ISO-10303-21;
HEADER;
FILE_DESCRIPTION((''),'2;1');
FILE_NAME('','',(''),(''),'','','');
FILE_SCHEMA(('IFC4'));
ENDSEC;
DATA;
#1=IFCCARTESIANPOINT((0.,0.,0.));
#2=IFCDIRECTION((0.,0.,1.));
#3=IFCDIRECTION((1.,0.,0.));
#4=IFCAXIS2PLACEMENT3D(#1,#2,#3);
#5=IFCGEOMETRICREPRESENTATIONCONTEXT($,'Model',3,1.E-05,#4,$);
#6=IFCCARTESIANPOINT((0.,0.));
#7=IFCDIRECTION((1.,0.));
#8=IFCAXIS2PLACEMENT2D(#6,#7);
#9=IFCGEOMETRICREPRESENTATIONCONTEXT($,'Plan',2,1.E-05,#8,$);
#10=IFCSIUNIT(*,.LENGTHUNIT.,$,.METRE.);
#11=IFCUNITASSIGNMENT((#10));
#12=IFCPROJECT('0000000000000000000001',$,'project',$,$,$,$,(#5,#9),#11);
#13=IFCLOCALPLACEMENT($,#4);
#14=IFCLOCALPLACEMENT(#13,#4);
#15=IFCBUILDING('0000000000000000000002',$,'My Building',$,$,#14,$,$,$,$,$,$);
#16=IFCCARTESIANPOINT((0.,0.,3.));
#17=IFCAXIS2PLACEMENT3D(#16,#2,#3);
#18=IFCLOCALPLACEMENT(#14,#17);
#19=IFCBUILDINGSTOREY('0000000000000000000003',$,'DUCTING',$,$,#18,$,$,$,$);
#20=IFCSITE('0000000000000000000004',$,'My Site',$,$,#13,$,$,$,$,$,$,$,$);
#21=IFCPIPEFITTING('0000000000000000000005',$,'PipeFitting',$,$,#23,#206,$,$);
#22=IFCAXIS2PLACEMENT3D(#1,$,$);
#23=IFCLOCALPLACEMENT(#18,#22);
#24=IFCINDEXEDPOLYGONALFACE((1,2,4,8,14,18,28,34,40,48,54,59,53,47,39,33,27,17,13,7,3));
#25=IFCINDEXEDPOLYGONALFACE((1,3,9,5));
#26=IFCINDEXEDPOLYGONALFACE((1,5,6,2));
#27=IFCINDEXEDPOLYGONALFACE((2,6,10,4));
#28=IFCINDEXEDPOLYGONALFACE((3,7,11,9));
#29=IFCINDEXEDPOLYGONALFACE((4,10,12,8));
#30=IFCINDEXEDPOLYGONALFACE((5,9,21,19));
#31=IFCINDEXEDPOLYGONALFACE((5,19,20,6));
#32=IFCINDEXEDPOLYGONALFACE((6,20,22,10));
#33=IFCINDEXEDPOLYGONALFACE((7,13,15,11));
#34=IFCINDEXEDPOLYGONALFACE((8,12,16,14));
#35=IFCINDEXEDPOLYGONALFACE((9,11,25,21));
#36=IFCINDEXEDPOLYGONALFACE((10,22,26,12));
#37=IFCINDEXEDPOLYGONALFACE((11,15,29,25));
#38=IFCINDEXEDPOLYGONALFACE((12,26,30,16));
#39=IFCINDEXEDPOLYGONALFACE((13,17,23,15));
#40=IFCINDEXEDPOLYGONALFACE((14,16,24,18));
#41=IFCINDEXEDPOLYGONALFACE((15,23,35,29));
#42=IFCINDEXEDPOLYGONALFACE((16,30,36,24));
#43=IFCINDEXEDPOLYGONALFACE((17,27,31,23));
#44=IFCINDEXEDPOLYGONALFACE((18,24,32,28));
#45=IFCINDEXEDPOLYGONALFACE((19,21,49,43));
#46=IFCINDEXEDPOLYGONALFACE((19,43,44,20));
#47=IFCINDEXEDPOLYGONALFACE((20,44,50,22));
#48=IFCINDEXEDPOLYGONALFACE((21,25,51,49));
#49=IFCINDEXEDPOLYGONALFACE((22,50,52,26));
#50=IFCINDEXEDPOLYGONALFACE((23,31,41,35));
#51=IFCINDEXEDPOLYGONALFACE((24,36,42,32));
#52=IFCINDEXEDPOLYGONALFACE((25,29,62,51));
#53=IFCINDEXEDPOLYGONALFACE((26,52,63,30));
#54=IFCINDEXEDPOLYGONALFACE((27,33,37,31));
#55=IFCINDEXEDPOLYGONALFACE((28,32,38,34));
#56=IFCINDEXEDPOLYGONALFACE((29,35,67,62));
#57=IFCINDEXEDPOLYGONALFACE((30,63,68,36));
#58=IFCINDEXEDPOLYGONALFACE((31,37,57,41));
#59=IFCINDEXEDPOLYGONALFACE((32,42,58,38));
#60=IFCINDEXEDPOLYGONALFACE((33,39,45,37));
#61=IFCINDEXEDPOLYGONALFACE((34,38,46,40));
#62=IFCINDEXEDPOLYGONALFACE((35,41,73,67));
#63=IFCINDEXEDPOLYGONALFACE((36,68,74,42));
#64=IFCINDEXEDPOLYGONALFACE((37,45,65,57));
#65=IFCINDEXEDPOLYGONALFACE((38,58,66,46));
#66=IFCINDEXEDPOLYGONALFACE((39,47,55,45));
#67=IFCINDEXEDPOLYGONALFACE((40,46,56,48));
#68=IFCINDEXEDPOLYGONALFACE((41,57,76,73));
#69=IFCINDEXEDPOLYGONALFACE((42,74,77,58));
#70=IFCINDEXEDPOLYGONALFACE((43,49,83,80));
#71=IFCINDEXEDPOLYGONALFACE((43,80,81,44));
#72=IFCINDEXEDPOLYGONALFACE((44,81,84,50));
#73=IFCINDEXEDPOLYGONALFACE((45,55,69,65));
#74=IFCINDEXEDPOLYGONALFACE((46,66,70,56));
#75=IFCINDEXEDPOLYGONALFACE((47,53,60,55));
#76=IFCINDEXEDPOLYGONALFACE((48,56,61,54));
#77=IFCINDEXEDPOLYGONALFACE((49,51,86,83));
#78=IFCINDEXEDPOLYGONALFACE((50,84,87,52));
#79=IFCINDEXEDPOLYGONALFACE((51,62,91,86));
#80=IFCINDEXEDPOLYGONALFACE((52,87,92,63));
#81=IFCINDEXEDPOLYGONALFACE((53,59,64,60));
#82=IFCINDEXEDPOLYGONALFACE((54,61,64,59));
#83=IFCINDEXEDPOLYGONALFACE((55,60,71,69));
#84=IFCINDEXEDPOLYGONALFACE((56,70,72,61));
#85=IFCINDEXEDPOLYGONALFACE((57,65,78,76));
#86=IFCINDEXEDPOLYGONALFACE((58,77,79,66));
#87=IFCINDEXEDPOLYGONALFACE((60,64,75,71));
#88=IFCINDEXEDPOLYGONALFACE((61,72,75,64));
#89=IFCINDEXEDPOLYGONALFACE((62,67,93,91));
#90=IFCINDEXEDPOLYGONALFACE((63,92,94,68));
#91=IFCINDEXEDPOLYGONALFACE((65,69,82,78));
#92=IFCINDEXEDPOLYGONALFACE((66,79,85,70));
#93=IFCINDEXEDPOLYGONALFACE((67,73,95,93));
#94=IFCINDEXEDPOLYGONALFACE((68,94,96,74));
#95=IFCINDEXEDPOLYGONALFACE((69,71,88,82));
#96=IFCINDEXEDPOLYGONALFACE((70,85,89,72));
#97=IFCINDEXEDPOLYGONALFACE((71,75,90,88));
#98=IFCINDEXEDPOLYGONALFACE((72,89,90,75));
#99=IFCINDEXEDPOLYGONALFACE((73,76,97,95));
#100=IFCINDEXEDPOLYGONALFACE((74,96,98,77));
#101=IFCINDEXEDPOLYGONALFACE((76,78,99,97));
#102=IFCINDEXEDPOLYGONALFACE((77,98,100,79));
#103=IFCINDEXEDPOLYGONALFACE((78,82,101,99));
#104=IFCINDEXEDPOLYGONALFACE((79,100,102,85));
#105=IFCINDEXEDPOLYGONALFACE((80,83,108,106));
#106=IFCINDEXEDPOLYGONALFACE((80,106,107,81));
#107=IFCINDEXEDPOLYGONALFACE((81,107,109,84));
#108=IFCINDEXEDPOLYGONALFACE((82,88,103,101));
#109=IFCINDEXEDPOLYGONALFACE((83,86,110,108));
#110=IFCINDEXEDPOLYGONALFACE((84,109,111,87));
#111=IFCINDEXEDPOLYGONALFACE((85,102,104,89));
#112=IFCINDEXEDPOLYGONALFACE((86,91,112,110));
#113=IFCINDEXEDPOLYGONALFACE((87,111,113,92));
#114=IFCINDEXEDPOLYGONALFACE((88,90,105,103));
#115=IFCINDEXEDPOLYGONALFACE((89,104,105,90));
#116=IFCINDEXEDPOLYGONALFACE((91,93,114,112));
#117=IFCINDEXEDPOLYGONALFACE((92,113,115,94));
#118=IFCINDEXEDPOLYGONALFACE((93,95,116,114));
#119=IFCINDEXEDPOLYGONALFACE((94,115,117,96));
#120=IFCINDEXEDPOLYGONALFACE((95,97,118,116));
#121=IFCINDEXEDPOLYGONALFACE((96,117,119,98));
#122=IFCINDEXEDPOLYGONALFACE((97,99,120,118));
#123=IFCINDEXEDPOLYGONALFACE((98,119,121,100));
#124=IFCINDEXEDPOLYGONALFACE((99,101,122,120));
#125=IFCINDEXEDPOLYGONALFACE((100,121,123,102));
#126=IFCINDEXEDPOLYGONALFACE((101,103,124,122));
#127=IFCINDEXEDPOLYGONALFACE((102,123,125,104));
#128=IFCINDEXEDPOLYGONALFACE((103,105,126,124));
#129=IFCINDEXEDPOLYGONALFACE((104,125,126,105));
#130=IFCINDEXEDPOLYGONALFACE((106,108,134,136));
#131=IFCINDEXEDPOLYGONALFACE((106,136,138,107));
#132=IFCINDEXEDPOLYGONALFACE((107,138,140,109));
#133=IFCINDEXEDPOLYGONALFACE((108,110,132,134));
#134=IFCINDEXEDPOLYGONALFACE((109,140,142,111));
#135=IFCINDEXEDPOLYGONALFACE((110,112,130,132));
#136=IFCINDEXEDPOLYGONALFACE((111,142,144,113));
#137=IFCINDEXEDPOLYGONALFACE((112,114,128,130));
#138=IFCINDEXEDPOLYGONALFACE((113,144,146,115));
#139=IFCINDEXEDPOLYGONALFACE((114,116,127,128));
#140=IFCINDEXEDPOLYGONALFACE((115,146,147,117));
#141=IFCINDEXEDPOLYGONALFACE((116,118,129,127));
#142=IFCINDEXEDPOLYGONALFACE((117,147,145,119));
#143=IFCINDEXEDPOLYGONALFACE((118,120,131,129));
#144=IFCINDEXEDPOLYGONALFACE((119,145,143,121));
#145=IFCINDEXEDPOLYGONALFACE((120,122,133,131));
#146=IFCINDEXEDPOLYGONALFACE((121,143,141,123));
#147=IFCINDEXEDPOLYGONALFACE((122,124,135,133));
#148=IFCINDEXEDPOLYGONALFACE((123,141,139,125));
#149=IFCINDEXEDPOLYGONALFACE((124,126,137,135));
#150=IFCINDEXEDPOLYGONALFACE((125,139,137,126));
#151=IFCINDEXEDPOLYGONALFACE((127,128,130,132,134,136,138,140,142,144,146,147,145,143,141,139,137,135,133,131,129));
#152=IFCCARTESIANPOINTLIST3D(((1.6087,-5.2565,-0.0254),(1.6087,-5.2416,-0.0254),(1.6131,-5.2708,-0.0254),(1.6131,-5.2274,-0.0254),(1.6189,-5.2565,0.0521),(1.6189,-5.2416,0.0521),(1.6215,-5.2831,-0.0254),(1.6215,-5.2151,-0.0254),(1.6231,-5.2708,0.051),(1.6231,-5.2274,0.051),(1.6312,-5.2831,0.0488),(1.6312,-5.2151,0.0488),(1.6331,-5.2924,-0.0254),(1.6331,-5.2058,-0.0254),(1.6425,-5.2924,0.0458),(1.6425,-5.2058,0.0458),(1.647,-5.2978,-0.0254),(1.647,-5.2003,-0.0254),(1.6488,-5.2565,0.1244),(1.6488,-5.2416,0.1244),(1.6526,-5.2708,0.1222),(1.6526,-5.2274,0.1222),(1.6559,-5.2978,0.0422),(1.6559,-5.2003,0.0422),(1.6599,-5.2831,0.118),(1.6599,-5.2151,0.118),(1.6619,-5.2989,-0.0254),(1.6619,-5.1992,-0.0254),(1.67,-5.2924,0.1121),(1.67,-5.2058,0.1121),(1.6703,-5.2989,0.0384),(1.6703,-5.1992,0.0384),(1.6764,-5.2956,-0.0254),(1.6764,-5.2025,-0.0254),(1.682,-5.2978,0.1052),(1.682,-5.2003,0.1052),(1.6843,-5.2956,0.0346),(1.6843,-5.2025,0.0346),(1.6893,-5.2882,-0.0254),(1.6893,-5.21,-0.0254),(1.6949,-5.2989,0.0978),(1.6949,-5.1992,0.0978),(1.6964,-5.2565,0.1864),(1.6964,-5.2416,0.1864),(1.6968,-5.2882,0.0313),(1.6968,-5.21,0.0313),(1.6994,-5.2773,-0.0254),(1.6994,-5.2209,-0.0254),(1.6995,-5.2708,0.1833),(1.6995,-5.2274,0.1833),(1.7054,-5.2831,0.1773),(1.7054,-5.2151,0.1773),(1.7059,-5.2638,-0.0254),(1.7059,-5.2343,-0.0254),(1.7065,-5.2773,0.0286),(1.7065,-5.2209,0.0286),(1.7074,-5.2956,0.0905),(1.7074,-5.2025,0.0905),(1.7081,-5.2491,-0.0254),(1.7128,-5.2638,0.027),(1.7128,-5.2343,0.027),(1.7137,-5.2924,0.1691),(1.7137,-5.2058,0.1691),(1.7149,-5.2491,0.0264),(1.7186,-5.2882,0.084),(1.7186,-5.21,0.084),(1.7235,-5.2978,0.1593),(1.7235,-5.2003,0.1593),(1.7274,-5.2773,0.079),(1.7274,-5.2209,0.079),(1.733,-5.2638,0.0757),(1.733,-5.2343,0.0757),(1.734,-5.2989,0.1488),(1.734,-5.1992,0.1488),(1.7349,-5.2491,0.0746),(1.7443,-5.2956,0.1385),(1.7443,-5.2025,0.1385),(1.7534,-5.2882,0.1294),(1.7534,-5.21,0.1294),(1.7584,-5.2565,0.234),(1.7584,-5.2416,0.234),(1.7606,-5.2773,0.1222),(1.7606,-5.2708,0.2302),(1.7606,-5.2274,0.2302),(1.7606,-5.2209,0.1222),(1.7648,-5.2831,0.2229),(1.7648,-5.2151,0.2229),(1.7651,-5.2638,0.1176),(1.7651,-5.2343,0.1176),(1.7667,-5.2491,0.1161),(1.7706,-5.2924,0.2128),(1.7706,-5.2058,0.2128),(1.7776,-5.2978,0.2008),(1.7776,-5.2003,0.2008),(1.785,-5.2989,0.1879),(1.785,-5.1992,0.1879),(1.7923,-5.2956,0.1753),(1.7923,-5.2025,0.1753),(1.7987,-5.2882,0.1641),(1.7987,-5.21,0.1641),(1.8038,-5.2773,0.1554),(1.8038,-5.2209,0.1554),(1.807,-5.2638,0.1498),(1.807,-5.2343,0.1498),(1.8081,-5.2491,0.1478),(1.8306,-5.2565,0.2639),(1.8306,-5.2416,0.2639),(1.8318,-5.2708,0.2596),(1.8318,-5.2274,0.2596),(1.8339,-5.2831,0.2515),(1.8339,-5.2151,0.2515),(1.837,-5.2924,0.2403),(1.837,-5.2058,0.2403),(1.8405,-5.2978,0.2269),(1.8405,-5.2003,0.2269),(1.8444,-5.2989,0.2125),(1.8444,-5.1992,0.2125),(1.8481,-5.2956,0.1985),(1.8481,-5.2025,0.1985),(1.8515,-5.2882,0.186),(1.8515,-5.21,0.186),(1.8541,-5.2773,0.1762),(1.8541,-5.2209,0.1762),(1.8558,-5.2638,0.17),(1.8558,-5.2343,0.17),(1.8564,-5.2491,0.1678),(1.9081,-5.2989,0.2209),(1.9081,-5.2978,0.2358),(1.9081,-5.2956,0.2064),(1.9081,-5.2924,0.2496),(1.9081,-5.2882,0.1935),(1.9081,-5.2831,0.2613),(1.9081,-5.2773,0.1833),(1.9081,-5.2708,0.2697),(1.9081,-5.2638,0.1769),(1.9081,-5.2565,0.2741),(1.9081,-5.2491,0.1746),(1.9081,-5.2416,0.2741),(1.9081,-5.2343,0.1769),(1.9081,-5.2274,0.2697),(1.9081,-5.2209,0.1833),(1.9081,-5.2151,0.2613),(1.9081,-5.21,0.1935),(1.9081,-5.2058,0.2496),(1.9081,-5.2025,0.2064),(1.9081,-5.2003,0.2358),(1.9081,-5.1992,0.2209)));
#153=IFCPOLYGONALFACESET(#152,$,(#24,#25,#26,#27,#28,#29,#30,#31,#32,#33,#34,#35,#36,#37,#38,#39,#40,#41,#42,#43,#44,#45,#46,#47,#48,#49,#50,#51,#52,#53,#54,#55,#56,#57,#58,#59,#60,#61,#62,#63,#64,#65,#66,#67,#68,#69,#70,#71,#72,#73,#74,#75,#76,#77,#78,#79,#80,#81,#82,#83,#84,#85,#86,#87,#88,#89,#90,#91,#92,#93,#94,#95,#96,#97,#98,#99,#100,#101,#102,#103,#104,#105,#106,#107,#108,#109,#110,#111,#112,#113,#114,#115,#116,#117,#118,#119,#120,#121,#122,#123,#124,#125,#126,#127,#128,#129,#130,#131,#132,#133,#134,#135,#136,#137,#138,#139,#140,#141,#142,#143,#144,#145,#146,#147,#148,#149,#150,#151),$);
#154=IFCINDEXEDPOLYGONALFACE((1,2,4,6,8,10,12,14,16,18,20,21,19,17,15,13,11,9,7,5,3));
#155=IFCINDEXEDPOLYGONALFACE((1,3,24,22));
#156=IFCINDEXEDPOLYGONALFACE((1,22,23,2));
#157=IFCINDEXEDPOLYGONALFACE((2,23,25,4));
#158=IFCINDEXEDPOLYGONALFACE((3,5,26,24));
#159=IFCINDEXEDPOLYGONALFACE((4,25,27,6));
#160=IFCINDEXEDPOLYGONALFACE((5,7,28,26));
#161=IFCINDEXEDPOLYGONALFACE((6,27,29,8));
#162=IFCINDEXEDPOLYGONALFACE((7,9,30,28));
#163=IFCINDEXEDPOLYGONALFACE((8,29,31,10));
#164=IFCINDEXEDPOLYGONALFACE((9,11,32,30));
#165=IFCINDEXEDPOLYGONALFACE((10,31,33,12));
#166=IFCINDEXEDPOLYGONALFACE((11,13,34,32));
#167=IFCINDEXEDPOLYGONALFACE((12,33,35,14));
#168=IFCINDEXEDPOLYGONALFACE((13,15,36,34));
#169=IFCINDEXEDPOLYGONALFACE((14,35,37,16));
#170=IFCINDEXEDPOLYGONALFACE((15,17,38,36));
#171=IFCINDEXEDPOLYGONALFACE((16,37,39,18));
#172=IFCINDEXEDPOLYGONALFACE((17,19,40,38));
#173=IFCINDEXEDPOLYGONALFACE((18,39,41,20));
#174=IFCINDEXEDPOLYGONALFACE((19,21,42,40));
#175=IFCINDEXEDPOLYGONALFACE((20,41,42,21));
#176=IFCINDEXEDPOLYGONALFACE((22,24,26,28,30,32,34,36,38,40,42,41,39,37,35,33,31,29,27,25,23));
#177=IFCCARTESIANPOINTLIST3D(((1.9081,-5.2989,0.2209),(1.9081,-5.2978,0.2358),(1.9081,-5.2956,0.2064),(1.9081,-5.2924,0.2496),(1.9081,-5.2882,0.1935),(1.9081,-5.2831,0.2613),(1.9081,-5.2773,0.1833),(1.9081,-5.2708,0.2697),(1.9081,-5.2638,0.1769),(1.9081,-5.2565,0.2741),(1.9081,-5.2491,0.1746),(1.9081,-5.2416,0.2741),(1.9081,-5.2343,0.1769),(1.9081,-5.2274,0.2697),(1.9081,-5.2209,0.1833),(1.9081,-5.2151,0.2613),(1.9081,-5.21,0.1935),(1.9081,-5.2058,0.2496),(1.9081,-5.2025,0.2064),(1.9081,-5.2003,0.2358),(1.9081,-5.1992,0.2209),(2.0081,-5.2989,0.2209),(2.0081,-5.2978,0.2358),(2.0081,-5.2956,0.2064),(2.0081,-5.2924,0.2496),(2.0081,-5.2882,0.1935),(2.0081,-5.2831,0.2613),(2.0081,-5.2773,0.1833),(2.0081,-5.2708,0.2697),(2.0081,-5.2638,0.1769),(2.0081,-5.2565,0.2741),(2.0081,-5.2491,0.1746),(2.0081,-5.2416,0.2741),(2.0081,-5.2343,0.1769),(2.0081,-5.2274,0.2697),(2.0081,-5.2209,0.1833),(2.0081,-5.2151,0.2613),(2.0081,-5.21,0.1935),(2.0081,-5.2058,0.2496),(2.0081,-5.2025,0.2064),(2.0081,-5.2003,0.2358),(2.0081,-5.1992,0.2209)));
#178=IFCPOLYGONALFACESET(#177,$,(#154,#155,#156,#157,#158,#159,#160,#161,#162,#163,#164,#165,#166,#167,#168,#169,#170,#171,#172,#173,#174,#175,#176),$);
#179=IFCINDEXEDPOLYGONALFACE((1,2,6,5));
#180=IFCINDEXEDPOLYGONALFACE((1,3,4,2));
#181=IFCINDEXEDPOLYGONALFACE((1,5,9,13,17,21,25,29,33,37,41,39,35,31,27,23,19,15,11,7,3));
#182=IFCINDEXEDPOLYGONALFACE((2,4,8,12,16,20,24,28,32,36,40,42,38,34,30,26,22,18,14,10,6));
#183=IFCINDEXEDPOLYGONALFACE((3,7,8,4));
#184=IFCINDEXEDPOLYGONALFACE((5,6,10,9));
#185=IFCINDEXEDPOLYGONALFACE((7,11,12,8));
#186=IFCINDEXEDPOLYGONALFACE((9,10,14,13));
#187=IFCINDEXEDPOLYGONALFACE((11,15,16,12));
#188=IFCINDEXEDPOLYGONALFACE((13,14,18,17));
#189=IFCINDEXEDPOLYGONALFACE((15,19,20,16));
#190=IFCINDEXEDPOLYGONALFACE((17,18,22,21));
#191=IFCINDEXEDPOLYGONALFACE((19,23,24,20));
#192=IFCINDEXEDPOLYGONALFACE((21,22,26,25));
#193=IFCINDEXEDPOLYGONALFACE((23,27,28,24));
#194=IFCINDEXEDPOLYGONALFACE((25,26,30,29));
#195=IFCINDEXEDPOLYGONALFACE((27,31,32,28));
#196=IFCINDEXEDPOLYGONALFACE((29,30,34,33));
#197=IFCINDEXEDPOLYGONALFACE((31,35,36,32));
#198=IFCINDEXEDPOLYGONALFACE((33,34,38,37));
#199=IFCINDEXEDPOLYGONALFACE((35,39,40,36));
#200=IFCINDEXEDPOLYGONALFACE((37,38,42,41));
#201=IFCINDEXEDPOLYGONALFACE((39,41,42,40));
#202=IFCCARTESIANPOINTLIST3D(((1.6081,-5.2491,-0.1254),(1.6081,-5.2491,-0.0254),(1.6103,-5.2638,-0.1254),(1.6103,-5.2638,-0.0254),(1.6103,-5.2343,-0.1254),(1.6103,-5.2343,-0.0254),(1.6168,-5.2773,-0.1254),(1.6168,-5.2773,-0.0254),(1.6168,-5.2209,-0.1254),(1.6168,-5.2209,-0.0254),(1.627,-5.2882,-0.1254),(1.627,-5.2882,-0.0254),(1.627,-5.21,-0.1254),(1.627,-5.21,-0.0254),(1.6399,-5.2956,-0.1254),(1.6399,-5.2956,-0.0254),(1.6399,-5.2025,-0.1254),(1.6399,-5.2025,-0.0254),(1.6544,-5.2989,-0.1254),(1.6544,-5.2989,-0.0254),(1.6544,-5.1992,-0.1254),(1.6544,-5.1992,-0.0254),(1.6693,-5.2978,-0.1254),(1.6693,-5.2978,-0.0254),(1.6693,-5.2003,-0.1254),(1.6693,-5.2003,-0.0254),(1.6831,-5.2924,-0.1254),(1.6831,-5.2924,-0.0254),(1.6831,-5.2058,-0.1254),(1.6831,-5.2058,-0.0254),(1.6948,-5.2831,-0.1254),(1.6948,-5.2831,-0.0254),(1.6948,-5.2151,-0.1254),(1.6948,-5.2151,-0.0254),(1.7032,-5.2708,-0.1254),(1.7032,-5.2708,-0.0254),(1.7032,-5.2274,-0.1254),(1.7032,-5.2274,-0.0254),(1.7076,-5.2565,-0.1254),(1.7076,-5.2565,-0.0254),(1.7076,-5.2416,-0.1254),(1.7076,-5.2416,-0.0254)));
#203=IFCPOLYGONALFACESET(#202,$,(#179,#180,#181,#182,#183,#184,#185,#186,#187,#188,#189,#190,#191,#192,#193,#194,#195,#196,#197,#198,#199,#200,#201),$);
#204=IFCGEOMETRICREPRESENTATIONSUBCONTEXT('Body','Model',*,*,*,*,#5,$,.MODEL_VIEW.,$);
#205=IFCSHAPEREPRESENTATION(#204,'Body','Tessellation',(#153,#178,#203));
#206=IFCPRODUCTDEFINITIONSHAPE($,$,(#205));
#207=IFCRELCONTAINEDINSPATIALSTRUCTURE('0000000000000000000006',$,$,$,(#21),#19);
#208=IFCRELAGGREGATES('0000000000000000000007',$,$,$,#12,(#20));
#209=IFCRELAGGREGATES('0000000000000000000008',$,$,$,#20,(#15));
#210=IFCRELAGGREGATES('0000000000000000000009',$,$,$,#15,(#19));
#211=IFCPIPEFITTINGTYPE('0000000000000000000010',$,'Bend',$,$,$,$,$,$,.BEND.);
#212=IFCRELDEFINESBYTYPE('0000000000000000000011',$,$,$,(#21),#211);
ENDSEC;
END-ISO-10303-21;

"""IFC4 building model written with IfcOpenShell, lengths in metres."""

from ifc_helpers import new_model, entity, si_unit, frame, origin_with_axes, origin_2d_with_axis, place, context, subcontext, project, spatial, circle, extrude, source, transform, mapped, type_object, type_shapes, element, save


model = new_model("IFC4")

# Units and contexts
model_context = context("Model", 3, precision=1e-05, world=origin_with_axes())
plan_context = context("Plan", 2, precision=1e-05, world=origin_2d_with_axis())
body_context = subcontext(model_context, "Body", "Model", "MODEL_VIEW")
ifc_project = project(units=[si_unit("LENGTHUNIT", "METRE")], contexts=[model_context, plan_context])

# Site, building, storey
site_placement = place(None, origin_with_axes())
site = spatial("IfcSite", under=ifc_project, at=site_placement, Name="My Site")
building_placement = place(site_placement, origin_with_axes())
building = spatial("IfcBuilding", under=site, at=building_placement, Name="My Building")
storey_placement = place(building_placement, frame((0.0, 0.0, 3.0), z_axis=(0.0, 0.0, 1.0), x_axis=(1.0, 0.0, 0.0)))
storey = spatial("IfcBuildingStorey", under=building, at=storey_placement, Name="DUCTING")

# Pipe fitting
pipe_fitting_type = type_object("IfcPipeFittingType", Name="Bend", PredefinedType="BEND")
shared_shape_1 = source(origin_with_axes(), body_context, "Body", "SolidModel", [
    entity("IfcSweptDiskSolid", entity("IfcIndexedPolyCurve", entity("IfcCartesianPointList3D", [[0.0, 0.0, 0.1], [0.0732, 0.0, 0.2768], [0.25, 0.0, 0.35]]), [entity("IfcArcIndex", [1, 2, 3])]), 0.05),
    extrude(circle(Radius=0.05), origin_with_axes(), (0.0, 0.0, 1.0), 0.1),
    extrude(circle(Radius=0.05), frame((0.25, 0.0, 0.35), z_axis=(1.0, 0.0, 0.0), x_axis=(0.0, 0.0, 1.0)), (0.0, 0.0, 1.0), 0.1),
])
type_shapes(pipe_fitting_type, [shared_shape_1])
for number, where, z_axis, x_axis, name in (
    (1, (2.0081, -5.2491, 0.2246), (-1.0, 0.0, 0.0), (0.0, 0.0, -1.0), "PipeFitting"),
):
    element("IfcPipeFitting", number, at=place(storey_placement, frame(where, z_axis=z_axis, x_axis=x_axis)), inside=storey, type_object=pipe_fitting_type, Name=name, context=body_context, shape_type="MappedRepresentation", body=[
        mapped(shared_shape_1, transform((0.0, 0.0, 0.0), x_axis=(1.0, 0.0, 0.0), y_axis=(0.0, 1.0, 0.0), z_axis=(0.0, 0.0, 1.0), scale=1.0)),
    ])

save(model, "model.ifc")
